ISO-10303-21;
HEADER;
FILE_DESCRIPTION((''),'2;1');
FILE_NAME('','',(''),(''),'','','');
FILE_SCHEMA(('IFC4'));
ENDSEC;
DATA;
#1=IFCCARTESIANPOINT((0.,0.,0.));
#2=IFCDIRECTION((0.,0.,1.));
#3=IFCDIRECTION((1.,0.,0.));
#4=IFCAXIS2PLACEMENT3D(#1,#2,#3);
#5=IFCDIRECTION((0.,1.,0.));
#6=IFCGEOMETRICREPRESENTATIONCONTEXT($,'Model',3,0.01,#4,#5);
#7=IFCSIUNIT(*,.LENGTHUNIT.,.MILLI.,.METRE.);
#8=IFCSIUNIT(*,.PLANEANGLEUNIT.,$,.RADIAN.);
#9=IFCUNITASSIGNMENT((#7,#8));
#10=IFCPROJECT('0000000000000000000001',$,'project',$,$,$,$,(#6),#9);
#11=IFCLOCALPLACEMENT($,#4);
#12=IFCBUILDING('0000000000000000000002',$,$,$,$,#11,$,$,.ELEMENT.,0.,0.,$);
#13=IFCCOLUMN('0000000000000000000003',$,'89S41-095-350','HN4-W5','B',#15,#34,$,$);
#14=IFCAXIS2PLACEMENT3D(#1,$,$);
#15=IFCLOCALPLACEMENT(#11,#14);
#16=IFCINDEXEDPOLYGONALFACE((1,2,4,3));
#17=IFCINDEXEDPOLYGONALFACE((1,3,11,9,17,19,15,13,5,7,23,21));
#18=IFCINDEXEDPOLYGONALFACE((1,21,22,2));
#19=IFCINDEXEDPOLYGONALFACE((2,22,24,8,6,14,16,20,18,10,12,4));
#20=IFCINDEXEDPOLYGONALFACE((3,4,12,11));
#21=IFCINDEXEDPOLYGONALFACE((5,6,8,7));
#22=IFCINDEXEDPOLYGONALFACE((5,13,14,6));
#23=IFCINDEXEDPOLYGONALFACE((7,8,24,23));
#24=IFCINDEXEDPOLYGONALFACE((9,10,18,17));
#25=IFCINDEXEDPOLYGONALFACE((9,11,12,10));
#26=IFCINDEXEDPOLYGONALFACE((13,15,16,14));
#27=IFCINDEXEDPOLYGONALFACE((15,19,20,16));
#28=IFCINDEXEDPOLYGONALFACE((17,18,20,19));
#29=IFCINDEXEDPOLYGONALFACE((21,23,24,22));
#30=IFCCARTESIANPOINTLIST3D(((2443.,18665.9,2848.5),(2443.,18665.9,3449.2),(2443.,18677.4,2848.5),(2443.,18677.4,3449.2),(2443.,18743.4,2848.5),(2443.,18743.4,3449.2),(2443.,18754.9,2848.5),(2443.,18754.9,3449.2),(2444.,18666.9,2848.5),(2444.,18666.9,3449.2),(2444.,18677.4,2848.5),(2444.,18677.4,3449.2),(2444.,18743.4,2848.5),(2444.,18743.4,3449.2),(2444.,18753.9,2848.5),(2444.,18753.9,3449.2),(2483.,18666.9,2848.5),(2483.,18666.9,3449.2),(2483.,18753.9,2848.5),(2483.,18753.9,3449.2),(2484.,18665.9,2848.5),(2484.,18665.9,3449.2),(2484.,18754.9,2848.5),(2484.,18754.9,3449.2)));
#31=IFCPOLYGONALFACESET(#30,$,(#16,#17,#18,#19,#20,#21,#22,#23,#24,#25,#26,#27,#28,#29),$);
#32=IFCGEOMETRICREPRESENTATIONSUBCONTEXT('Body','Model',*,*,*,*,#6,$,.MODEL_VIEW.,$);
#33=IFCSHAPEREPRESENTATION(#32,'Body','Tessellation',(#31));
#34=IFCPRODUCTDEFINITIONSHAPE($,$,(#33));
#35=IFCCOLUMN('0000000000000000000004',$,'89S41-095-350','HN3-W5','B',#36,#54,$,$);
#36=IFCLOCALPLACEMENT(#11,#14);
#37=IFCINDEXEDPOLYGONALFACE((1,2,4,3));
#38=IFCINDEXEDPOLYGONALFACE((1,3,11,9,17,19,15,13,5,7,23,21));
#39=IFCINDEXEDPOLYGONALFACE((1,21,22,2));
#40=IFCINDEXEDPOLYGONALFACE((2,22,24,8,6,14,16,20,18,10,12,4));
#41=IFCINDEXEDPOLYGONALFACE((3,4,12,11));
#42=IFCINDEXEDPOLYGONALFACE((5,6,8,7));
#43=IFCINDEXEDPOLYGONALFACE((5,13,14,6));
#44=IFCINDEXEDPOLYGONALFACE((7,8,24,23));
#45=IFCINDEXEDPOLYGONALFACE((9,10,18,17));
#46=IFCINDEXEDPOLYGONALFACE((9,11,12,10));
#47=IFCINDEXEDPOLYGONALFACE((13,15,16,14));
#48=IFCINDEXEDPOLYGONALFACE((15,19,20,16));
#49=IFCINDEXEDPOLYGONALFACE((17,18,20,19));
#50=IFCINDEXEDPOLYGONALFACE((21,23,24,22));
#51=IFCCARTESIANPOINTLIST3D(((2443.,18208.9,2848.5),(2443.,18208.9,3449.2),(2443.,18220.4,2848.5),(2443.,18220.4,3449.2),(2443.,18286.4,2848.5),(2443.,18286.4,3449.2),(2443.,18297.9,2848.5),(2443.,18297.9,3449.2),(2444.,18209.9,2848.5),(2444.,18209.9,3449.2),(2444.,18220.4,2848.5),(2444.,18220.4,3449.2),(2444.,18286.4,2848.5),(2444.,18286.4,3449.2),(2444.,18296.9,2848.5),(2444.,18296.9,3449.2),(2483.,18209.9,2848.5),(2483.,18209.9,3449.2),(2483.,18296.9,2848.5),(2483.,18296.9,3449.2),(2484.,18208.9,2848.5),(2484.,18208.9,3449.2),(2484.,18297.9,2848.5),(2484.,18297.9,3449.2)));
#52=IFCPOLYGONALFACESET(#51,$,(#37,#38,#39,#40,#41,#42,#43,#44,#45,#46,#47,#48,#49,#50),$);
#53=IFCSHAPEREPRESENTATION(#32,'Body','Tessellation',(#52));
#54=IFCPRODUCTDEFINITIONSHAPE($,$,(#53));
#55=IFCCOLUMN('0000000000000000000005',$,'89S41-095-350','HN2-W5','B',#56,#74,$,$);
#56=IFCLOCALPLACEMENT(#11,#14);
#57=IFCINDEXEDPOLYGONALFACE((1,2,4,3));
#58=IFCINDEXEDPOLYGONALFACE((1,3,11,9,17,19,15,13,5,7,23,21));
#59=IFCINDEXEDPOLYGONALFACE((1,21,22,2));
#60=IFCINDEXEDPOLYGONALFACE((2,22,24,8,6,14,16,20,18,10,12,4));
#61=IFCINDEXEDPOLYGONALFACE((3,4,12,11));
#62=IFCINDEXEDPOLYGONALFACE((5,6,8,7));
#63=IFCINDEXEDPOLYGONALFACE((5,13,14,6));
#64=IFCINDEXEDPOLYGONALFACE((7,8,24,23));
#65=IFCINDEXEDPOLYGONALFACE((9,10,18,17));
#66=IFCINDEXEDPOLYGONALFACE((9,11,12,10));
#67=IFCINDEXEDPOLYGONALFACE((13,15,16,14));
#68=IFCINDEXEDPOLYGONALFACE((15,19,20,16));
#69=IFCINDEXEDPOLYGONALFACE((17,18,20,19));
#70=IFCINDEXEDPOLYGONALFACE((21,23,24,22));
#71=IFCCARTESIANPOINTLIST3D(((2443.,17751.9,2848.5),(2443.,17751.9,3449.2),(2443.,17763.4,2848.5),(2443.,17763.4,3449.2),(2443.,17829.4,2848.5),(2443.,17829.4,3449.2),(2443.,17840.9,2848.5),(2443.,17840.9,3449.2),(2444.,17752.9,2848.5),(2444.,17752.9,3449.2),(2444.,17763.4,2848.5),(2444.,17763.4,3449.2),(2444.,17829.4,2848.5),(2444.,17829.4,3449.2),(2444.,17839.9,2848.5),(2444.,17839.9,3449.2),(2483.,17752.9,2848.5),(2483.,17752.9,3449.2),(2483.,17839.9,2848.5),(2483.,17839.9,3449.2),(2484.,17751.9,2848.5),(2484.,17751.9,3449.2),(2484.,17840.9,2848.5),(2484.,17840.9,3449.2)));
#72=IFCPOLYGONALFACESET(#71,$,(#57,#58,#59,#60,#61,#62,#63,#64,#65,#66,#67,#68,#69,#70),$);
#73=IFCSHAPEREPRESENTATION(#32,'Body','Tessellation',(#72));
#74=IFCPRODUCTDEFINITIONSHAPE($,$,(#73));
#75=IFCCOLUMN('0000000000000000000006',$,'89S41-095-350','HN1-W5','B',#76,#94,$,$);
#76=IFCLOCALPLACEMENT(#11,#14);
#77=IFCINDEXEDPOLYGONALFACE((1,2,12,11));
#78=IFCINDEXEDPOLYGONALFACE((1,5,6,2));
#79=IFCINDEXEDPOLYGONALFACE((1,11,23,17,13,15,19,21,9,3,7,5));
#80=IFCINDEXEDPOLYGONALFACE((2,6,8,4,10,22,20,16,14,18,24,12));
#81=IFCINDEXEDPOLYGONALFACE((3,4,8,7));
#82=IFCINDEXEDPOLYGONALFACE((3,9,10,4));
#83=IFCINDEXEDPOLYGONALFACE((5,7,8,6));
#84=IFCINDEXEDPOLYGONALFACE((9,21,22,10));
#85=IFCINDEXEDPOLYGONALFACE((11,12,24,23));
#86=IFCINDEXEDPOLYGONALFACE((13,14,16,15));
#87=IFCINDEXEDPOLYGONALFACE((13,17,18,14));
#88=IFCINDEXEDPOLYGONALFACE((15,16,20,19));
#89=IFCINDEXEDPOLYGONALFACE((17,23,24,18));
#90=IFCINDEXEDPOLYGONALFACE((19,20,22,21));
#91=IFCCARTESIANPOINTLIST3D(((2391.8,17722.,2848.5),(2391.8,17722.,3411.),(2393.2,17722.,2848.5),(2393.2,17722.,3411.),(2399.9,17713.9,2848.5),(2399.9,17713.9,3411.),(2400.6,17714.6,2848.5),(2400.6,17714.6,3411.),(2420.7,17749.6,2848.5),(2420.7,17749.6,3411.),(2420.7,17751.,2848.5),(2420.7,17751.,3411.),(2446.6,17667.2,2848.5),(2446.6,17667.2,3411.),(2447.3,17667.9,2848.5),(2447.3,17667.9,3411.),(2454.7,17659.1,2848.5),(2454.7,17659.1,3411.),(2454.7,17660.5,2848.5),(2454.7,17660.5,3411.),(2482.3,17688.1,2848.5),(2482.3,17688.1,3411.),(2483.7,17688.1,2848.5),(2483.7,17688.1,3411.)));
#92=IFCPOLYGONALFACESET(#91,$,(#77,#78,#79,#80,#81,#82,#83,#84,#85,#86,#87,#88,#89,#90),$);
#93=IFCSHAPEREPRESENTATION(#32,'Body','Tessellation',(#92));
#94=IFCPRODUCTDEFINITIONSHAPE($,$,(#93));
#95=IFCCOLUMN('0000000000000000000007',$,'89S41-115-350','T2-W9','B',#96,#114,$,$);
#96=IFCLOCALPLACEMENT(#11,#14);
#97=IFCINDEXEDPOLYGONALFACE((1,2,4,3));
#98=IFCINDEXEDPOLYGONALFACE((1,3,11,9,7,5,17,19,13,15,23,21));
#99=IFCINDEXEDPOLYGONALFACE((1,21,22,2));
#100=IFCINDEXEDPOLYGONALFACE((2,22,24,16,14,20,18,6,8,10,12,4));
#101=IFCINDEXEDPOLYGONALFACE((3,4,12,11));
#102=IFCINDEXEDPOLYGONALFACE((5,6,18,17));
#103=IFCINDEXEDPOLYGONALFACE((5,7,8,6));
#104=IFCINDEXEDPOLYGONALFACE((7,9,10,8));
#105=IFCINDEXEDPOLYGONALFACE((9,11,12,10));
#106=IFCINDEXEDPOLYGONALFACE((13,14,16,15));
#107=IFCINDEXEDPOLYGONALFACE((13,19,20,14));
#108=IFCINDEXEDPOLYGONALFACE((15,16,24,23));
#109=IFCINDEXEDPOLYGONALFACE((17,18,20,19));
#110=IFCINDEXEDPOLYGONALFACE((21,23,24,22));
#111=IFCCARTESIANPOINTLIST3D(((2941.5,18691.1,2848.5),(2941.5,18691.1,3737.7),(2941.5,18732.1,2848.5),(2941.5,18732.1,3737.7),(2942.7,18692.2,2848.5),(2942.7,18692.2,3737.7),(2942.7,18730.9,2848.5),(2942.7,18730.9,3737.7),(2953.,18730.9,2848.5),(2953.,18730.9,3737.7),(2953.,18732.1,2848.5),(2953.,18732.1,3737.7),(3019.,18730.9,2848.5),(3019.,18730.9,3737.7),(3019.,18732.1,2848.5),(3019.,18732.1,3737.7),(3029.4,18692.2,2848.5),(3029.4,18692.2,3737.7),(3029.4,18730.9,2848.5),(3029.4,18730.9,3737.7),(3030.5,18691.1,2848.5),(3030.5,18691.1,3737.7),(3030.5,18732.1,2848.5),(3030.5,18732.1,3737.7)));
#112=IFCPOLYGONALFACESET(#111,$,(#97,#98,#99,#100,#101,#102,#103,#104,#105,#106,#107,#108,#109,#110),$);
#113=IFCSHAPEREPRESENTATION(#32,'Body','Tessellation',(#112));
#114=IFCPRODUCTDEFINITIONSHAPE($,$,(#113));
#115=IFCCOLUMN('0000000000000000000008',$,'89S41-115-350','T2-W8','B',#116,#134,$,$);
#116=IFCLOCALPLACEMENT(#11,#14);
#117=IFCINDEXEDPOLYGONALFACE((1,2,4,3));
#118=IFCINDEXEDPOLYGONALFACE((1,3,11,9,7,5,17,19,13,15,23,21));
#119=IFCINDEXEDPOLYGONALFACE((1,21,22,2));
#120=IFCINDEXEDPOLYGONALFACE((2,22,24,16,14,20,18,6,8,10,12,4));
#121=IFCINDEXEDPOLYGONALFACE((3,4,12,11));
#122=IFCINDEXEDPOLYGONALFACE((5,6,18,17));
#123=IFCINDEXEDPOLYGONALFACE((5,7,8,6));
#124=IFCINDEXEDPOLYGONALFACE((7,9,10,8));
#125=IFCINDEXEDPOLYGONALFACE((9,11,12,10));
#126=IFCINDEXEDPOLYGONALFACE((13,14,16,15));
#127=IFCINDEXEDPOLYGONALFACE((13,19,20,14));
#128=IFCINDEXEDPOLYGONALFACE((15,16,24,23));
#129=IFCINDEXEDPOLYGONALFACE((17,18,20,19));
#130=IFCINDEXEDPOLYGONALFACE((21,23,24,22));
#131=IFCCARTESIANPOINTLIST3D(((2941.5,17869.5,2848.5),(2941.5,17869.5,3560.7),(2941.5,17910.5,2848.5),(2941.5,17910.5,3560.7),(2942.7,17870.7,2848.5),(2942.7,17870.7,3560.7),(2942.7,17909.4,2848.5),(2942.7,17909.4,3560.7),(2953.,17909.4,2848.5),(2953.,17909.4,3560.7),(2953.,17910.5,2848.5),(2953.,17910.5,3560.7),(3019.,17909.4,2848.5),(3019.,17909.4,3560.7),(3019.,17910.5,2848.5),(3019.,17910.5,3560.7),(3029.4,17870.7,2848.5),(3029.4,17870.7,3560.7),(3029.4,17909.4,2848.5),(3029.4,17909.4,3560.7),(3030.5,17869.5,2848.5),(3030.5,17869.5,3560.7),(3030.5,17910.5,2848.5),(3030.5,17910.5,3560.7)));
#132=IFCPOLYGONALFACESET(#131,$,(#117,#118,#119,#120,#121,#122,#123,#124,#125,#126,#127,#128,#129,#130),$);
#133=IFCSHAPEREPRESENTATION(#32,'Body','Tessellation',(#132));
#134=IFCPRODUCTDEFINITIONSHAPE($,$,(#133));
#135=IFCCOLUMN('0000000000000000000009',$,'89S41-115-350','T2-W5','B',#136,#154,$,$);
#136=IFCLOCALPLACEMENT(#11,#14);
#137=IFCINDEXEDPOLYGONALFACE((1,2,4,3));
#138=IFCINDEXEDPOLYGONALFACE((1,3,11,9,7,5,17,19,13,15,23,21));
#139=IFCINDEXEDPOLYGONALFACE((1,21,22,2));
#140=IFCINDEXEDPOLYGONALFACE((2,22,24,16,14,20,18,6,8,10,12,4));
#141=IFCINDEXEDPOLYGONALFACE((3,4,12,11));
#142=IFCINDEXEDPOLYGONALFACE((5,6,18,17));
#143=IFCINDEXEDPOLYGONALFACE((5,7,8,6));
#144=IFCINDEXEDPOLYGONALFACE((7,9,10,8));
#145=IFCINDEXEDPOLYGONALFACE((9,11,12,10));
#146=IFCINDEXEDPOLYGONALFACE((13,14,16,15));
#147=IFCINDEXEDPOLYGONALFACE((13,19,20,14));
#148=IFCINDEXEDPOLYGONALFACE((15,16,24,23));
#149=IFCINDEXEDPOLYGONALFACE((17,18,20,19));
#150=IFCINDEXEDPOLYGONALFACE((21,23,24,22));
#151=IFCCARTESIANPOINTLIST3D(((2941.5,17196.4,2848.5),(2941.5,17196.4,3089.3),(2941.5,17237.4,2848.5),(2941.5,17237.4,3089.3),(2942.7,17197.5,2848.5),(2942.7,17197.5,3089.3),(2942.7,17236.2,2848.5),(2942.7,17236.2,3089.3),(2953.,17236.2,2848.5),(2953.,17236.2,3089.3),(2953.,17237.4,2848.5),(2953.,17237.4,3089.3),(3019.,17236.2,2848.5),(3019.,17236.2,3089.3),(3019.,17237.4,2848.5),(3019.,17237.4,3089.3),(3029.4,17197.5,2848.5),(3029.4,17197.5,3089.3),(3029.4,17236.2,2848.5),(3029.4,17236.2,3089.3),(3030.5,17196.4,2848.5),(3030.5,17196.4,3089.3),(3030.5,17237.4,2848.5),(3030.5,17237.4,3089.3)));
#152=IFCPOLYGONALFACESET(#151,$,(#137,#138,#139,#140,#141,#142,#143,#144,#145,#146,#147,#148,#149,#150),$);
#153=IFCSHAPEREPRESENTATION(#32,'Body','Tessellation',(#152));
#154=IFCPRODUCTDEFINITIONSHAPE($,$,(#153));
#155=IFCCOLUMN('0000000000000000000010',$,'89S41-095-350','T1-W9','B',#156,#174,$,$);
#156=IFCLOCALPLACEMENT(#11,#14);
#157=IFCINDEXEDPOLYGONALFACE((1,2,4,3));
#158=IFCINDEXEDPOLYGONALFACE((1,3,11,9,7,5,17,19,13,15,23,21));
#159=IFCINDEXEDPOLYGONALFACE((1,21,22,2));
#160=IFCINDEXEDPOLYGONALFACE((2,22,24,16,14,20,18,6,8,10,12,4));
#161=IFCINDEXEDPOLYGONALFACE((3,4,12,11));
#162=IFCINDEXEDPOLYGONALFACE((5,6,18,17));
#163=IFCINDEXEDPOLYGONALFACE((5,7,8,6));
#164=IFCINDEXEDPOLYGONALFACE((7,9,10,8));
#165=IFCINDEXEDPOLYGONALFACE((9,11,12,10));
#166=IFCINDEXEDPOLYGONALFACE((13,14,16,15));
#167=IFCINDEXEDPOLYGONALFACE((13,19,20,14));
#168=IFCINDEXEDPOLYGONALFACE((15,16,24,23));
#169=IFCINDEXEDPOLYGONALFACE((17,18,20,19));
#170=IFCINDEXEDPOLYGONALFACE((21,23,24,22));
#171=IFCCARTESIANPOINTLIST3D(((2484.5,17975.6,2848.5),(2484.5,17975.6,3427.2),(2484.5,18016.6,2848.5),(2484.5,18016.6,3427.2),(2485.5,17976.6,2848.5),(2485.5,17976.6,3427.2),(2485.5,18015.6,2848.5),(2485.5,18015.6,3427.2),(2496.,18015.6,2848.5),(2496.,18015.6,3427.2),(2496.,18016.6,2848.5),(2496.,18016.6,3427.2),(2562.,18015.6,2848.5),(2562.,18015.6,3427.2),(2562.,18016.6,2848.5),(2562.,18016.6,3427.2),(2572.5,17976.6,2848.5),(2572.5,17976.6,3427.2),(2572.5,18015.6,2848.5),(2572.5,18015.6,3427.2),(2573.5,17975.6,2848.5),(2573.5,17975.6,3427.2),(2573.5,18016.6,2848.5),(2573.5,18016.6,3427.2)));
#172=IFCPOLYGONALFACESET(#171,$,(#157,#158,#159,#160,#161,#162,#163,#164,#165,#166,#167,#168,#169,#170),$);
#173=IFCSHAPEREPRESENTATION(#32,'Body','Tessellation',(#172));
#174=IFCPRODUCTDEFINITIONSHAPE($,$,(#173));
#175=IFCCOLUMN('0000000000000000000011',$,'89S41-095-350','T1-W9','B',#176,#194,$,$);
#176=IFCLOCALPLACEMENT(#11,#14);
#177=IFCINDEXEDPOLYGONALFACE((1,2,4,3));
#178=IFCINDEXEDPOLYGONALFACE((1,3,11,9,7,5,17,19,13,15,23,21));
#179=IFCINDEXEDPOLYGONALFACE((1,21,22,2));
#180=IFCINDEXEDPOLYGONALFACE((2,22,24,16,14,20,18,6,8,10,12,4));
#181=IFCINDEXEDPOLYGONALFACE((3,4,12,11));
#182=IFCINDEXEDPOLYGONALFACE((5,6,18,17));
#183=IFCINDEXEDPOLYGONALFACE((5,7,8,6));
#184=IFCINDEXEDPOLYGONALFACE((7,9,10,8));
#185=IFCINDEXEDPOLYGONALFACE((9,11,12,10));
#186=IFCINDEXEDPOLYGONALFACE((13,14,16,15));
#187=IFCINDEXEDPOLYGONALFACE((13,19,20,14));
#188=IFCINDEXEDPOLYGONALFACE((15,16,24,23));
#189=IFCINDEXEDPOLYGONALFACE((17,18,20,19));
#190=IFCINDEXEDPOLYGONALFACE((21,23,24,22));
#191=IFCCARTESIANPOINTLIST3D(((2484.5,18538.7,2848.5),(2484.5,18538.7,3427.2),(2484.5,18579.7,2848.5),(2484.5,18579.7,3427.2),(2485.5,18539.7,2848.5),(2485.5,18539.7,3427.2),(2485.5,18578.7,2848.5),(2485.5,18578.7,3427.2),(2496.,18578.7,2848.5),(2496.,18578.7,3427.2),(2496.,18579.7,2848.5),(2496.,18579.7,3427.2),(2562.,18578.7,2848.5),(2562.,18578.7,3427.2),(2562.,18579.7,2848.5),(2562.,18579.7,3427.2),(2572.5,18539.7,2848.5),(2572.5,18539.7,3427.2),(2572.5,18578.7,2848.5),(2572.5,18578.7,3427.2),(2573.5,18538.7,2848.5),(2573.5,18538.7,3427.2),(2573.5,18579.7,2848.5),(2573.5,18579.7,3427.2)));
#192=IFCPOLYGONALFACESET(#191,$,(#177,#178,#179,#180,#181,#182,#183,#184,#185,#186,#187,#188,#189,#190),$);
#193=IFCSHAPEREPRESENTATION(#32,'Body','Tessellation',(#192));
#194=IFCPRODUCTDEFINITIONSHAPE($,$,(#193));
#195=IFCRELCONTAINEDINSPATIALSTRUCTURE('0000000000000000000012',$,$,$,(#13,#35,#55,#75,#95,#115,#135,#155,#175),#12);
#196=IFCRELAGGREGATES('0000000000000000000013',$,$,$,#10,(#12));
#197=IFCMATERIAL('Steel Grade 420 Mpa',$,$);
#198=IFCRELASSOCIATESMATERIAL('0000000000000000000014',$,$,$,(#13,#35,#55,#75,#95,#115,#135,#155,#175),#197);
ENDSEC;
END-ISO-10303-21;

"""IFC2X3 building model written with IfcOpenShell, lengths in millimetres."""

from ifc_helpers import new_model, si_unit, direction, frame, origin, origin_with_axes, origin_2d_with_axis, place, context, subcontext, project, spatial, c_section, extrude, source, transform, mapped, material, element, save


model = new_model("IFC2X3")

# Units and contexts
model_context = context("Model", 3, precision=0.01, world=origin_with_axes(), true_north=direction((0.0, 1.0, 0.0)))
body_context = subcontext(model_context, "Body", "Model", "MODEL_VIEW")
ifc_project = project(units=[si_unit("LENGTHUNIT", "METRE", prefix="MILLI"), si_unit("PLANEANGLEUNIT", "RADIAN")], contexts=[model_context])

# Building
building_placement = place(None, origin_with_axes())
building = spatial("IfcBuilding", under=ifc_project, at=building_placement, CompositionType="ELEMENT", ElevationOfRefHeight=0.0, ElevationOfTerrain=0.0)

# Columns
ifc_material = material(Name="Steel Grade 420 Mpa")
shared_shape_1 = source(origin(), body_context, "Body", "SweptSolid", [
    extrude(c_section(Depth=89.0, Width=41.0, WallThickness=1.0, Girth=11.5, at=origin_2d_with_axis()), origin_with_axes(), (0.0, 0.0, 1.0), 600.7),
])
column_1_placement = place(None, frame((2463.5, 18710.4, 2848.5), z_axis=(0.0, 0.0, 1.0), x_axis=(-1.0, 0.0, 0.0)))
element("IfcColumn", 1, at=column_1_placement, inside=building, material=ifc_material, Name="89S41-095-350", Description="HN4-W5", ObjectType="B", context=body_context, shape_type="MappedRepresentation", body=[
    mapped(shared_shape_1, transform((0.0, 0.0, 0.0), scale=1.0)),
])
shared_shape_2 = source(origin(), body_context, "Body", "SweptSolid", [
    extrude(c_section(Depth=89.0, Width=41.0, WallThickness=1.0, Girth=11.5, at=origin_2d_with_axis()), origin_with_axes(), (0.0, 0.0, 1.0), 600.7),
])
column_2_placement = place(None, frame((2463.5, 18253.4, 2848.5), z_axis=(0.0, 0.0, 1.0), x_axis=(-1.0, 0.0, 0.0)))
element("IfcColumn", 2, at=column_2_placement, inside=building, material=ifc_material, Name="89S41-095-350", Description="HN3-W5", ObjectType="B", context=body_context, shape_type="MappedRepresentation", body=[
    mapped(shared_shape_2, transform((0.0, 0.0, 0.0), scale=1.0)),
])
shared_shape_3 = source(origin(), body_context, "Body", "SweptSolid", [
    extrude(c_section(Depth=89.0, Width=41.0, WallThickness=1.0, Girth=11.5, at=origin_2d_with_axis()), origin_with_axes(), (0.0, 0.0, 1.0), 600.7),
])
column_3_placement = place(None, frame((2463.5, 17796.4, 2848.5), z_axis=(0.0, 0.0, 1.0), x_axis=(-1.0, 0.0, 0.0)))
element("IfcColumn", 3, at=column_3_placement, inside=building, material=ifc_material, Name="89S41-095-350", Description="HN2-W5", ObjectType="B", context=body_context, shape_type="MappedRepresentation", body=[
    mapped(shared_shape_3, transform((0.0, 0.0, 0.0), scale=1.0)),
])
shared_shape_4 = source(origin(), body_context, "Body", "SweptSolid", [
    extrude(c_section(Depth=89.0, Width=41.0, WallThickness=1.0, Girth=11.5, at=origin_2d_with_axis()), origin_with_axes(), (0.0, 0.0, 1.0), 562.5),
])
column_4_placement = place(None, frame((2437.7, 17705.1, 2848.5), z_axis=(0.0, 0.0, 1.0), x_axis=(-0.707107, -0.707107, 0.0)))
element("IfcColumn", 4, at=column_4_placement, inside=building, material=ifc_material, Name="89S41-095-350", Description="HN1-W5", ObjectType="B", context=body_context, shape_type="MappedRepresentation", body=[
    mapped(shared_shape_4, transform((0.0, 0.0, 0.0), scale=1.0)),
])
shared_shape_5 = source(origin(), body_context, "Body", "SweptSolid", [
    extrude(c_section(Depth=89.0, Width=41.0, WallThickness=1.1, Girth=11.5, at=origin_2d_with_axis()), origin_with_axes(), (0.0, 0.0, 1.0), 889.2),
])
column_5_placement = place(None, frame((2986.0, 18711.6, 2848.5), z_axis=(0.0, 0.0, 1.0), x_axis=(0.0, 1.0, 0.0)))
element("IfcColumn", 5, at=column_5_placement, inside=building, material=ifc_material, Name="89S41-115-350", Description="T2-W9", ObjectType="B", context=body_context, shape_type="MappedRepresentation", body=[
    mapped(shared_shape_5, transform((0.0, 0.0, 0.0), scale=1.0)),
])
shared_shape_6 = source(origin(), body_context, "Body", "SweptSolid", [
    extrude(c_section(Depth=89.0, Width=41.0, WallThickness=1.1, Girth=11.5, at=origin_2d_with_axis()), origin_with_axes(), (0.0, 0.0, 1.0), 712.2),
])
column_6_placement = place(None, frame((2986.0, 17890.0, 2848.5), z_axis=(0.0, 0.0, 1.0), x_axis=(0.0, 1.0, 0.0)))
element("IfcColumn", 6, at=column_6_placement, inside=building, material=ifc_material, Name="89S41-115-350", Description="T2-W8", ObjectType="B", context=body_context, shape_type="MappedRepresentation", body=[
    mapped(shared_shape_6, transform((0.0, 0.0, 0.0), scale=1.0)),
])
shared_shape_7 = source(origin(), body_context, "Body", "SweptSolid", [
    extrude(c_section(Depth=89.0, Width=41.0, WallThickness=1.1, Girth=11.5, at=origin_2d_with_axis()), origin_with_axes(), (0.0, 0.0, 1.0), 240.8),
])
column_7_placement = place(None, frame((2986.0, 17216.9, 2848.5), z_axis=(0.0, 0.0, 1.0), x_axis=(0.0, 1.0, 0.0)))
element("IfcColumn", 7, at=column_7_placement, inside=building, material=ifc_material, Name="89S41-115-350", Description="T2-W5", ObjectType="B", context=body_context, shape_type="MappedRepresentation", body=[
    mapped(shared_shape_7, transform((0.0, 0.0, 0.0), scale=1.0)),
])
shared_shape_8 = source(origin(), body_context, "Body", "SweptSolid", [
    extrude(c_section(Depth=89.0, Width=41.0, WallThickness=1.0, Girth=11.5, at=origin_2d_with_axis()), origin_with_axes(), (0.0, 0.0, 1.0), 578.7),
])
column_8_placement = place(None, frame((2529.0, 17996.1, 2848.5), z_axis=(0.0, 0.0, 1.0), x_axis=(0.0, 1.0, 0.0)))
element("IfcColumn", 8, at=column_8_placement, inside=building, material=ifc_material, Name="89S41-095-350", Description="T1-W9", ObjectType="B", context=body_context, shape_type="MappedRepresentation", body=[
    mapped(shared_shape_8, transform((0.0, 0.0, 0.0), scale=1.0)),
])
shared_shape_9 = source(origin(), body_context, "Body", "SweptSolid", [
    extrude(c_section(Depth=89.0, Width=41.0, WallThickness=1.0, Girth=11.5, at=origin_2d_with_axis()), origin_with_axes(), (0.0, 0.0, 1.0), 578.7),
])
column_9_placement = place(None, frame((2529.0, 18559.2, 2848.5), z_axis=(0.0, 0.0, 1.0), x_axis=(0.0, 1.0, 0.0)))
element("IfcColumn", 9, at=column_9_placement, inside=building, material=ifc_material, Name="89S41-095-350", Description="T1-W9", ObjectType="B", context=body_context, shape_type="MappedRepresentation", body=[
    mapped(shared_shape_9, transform((0.0, 0.0, 0.0), scale=1.0)),
])

save(model, "model.ifc")
